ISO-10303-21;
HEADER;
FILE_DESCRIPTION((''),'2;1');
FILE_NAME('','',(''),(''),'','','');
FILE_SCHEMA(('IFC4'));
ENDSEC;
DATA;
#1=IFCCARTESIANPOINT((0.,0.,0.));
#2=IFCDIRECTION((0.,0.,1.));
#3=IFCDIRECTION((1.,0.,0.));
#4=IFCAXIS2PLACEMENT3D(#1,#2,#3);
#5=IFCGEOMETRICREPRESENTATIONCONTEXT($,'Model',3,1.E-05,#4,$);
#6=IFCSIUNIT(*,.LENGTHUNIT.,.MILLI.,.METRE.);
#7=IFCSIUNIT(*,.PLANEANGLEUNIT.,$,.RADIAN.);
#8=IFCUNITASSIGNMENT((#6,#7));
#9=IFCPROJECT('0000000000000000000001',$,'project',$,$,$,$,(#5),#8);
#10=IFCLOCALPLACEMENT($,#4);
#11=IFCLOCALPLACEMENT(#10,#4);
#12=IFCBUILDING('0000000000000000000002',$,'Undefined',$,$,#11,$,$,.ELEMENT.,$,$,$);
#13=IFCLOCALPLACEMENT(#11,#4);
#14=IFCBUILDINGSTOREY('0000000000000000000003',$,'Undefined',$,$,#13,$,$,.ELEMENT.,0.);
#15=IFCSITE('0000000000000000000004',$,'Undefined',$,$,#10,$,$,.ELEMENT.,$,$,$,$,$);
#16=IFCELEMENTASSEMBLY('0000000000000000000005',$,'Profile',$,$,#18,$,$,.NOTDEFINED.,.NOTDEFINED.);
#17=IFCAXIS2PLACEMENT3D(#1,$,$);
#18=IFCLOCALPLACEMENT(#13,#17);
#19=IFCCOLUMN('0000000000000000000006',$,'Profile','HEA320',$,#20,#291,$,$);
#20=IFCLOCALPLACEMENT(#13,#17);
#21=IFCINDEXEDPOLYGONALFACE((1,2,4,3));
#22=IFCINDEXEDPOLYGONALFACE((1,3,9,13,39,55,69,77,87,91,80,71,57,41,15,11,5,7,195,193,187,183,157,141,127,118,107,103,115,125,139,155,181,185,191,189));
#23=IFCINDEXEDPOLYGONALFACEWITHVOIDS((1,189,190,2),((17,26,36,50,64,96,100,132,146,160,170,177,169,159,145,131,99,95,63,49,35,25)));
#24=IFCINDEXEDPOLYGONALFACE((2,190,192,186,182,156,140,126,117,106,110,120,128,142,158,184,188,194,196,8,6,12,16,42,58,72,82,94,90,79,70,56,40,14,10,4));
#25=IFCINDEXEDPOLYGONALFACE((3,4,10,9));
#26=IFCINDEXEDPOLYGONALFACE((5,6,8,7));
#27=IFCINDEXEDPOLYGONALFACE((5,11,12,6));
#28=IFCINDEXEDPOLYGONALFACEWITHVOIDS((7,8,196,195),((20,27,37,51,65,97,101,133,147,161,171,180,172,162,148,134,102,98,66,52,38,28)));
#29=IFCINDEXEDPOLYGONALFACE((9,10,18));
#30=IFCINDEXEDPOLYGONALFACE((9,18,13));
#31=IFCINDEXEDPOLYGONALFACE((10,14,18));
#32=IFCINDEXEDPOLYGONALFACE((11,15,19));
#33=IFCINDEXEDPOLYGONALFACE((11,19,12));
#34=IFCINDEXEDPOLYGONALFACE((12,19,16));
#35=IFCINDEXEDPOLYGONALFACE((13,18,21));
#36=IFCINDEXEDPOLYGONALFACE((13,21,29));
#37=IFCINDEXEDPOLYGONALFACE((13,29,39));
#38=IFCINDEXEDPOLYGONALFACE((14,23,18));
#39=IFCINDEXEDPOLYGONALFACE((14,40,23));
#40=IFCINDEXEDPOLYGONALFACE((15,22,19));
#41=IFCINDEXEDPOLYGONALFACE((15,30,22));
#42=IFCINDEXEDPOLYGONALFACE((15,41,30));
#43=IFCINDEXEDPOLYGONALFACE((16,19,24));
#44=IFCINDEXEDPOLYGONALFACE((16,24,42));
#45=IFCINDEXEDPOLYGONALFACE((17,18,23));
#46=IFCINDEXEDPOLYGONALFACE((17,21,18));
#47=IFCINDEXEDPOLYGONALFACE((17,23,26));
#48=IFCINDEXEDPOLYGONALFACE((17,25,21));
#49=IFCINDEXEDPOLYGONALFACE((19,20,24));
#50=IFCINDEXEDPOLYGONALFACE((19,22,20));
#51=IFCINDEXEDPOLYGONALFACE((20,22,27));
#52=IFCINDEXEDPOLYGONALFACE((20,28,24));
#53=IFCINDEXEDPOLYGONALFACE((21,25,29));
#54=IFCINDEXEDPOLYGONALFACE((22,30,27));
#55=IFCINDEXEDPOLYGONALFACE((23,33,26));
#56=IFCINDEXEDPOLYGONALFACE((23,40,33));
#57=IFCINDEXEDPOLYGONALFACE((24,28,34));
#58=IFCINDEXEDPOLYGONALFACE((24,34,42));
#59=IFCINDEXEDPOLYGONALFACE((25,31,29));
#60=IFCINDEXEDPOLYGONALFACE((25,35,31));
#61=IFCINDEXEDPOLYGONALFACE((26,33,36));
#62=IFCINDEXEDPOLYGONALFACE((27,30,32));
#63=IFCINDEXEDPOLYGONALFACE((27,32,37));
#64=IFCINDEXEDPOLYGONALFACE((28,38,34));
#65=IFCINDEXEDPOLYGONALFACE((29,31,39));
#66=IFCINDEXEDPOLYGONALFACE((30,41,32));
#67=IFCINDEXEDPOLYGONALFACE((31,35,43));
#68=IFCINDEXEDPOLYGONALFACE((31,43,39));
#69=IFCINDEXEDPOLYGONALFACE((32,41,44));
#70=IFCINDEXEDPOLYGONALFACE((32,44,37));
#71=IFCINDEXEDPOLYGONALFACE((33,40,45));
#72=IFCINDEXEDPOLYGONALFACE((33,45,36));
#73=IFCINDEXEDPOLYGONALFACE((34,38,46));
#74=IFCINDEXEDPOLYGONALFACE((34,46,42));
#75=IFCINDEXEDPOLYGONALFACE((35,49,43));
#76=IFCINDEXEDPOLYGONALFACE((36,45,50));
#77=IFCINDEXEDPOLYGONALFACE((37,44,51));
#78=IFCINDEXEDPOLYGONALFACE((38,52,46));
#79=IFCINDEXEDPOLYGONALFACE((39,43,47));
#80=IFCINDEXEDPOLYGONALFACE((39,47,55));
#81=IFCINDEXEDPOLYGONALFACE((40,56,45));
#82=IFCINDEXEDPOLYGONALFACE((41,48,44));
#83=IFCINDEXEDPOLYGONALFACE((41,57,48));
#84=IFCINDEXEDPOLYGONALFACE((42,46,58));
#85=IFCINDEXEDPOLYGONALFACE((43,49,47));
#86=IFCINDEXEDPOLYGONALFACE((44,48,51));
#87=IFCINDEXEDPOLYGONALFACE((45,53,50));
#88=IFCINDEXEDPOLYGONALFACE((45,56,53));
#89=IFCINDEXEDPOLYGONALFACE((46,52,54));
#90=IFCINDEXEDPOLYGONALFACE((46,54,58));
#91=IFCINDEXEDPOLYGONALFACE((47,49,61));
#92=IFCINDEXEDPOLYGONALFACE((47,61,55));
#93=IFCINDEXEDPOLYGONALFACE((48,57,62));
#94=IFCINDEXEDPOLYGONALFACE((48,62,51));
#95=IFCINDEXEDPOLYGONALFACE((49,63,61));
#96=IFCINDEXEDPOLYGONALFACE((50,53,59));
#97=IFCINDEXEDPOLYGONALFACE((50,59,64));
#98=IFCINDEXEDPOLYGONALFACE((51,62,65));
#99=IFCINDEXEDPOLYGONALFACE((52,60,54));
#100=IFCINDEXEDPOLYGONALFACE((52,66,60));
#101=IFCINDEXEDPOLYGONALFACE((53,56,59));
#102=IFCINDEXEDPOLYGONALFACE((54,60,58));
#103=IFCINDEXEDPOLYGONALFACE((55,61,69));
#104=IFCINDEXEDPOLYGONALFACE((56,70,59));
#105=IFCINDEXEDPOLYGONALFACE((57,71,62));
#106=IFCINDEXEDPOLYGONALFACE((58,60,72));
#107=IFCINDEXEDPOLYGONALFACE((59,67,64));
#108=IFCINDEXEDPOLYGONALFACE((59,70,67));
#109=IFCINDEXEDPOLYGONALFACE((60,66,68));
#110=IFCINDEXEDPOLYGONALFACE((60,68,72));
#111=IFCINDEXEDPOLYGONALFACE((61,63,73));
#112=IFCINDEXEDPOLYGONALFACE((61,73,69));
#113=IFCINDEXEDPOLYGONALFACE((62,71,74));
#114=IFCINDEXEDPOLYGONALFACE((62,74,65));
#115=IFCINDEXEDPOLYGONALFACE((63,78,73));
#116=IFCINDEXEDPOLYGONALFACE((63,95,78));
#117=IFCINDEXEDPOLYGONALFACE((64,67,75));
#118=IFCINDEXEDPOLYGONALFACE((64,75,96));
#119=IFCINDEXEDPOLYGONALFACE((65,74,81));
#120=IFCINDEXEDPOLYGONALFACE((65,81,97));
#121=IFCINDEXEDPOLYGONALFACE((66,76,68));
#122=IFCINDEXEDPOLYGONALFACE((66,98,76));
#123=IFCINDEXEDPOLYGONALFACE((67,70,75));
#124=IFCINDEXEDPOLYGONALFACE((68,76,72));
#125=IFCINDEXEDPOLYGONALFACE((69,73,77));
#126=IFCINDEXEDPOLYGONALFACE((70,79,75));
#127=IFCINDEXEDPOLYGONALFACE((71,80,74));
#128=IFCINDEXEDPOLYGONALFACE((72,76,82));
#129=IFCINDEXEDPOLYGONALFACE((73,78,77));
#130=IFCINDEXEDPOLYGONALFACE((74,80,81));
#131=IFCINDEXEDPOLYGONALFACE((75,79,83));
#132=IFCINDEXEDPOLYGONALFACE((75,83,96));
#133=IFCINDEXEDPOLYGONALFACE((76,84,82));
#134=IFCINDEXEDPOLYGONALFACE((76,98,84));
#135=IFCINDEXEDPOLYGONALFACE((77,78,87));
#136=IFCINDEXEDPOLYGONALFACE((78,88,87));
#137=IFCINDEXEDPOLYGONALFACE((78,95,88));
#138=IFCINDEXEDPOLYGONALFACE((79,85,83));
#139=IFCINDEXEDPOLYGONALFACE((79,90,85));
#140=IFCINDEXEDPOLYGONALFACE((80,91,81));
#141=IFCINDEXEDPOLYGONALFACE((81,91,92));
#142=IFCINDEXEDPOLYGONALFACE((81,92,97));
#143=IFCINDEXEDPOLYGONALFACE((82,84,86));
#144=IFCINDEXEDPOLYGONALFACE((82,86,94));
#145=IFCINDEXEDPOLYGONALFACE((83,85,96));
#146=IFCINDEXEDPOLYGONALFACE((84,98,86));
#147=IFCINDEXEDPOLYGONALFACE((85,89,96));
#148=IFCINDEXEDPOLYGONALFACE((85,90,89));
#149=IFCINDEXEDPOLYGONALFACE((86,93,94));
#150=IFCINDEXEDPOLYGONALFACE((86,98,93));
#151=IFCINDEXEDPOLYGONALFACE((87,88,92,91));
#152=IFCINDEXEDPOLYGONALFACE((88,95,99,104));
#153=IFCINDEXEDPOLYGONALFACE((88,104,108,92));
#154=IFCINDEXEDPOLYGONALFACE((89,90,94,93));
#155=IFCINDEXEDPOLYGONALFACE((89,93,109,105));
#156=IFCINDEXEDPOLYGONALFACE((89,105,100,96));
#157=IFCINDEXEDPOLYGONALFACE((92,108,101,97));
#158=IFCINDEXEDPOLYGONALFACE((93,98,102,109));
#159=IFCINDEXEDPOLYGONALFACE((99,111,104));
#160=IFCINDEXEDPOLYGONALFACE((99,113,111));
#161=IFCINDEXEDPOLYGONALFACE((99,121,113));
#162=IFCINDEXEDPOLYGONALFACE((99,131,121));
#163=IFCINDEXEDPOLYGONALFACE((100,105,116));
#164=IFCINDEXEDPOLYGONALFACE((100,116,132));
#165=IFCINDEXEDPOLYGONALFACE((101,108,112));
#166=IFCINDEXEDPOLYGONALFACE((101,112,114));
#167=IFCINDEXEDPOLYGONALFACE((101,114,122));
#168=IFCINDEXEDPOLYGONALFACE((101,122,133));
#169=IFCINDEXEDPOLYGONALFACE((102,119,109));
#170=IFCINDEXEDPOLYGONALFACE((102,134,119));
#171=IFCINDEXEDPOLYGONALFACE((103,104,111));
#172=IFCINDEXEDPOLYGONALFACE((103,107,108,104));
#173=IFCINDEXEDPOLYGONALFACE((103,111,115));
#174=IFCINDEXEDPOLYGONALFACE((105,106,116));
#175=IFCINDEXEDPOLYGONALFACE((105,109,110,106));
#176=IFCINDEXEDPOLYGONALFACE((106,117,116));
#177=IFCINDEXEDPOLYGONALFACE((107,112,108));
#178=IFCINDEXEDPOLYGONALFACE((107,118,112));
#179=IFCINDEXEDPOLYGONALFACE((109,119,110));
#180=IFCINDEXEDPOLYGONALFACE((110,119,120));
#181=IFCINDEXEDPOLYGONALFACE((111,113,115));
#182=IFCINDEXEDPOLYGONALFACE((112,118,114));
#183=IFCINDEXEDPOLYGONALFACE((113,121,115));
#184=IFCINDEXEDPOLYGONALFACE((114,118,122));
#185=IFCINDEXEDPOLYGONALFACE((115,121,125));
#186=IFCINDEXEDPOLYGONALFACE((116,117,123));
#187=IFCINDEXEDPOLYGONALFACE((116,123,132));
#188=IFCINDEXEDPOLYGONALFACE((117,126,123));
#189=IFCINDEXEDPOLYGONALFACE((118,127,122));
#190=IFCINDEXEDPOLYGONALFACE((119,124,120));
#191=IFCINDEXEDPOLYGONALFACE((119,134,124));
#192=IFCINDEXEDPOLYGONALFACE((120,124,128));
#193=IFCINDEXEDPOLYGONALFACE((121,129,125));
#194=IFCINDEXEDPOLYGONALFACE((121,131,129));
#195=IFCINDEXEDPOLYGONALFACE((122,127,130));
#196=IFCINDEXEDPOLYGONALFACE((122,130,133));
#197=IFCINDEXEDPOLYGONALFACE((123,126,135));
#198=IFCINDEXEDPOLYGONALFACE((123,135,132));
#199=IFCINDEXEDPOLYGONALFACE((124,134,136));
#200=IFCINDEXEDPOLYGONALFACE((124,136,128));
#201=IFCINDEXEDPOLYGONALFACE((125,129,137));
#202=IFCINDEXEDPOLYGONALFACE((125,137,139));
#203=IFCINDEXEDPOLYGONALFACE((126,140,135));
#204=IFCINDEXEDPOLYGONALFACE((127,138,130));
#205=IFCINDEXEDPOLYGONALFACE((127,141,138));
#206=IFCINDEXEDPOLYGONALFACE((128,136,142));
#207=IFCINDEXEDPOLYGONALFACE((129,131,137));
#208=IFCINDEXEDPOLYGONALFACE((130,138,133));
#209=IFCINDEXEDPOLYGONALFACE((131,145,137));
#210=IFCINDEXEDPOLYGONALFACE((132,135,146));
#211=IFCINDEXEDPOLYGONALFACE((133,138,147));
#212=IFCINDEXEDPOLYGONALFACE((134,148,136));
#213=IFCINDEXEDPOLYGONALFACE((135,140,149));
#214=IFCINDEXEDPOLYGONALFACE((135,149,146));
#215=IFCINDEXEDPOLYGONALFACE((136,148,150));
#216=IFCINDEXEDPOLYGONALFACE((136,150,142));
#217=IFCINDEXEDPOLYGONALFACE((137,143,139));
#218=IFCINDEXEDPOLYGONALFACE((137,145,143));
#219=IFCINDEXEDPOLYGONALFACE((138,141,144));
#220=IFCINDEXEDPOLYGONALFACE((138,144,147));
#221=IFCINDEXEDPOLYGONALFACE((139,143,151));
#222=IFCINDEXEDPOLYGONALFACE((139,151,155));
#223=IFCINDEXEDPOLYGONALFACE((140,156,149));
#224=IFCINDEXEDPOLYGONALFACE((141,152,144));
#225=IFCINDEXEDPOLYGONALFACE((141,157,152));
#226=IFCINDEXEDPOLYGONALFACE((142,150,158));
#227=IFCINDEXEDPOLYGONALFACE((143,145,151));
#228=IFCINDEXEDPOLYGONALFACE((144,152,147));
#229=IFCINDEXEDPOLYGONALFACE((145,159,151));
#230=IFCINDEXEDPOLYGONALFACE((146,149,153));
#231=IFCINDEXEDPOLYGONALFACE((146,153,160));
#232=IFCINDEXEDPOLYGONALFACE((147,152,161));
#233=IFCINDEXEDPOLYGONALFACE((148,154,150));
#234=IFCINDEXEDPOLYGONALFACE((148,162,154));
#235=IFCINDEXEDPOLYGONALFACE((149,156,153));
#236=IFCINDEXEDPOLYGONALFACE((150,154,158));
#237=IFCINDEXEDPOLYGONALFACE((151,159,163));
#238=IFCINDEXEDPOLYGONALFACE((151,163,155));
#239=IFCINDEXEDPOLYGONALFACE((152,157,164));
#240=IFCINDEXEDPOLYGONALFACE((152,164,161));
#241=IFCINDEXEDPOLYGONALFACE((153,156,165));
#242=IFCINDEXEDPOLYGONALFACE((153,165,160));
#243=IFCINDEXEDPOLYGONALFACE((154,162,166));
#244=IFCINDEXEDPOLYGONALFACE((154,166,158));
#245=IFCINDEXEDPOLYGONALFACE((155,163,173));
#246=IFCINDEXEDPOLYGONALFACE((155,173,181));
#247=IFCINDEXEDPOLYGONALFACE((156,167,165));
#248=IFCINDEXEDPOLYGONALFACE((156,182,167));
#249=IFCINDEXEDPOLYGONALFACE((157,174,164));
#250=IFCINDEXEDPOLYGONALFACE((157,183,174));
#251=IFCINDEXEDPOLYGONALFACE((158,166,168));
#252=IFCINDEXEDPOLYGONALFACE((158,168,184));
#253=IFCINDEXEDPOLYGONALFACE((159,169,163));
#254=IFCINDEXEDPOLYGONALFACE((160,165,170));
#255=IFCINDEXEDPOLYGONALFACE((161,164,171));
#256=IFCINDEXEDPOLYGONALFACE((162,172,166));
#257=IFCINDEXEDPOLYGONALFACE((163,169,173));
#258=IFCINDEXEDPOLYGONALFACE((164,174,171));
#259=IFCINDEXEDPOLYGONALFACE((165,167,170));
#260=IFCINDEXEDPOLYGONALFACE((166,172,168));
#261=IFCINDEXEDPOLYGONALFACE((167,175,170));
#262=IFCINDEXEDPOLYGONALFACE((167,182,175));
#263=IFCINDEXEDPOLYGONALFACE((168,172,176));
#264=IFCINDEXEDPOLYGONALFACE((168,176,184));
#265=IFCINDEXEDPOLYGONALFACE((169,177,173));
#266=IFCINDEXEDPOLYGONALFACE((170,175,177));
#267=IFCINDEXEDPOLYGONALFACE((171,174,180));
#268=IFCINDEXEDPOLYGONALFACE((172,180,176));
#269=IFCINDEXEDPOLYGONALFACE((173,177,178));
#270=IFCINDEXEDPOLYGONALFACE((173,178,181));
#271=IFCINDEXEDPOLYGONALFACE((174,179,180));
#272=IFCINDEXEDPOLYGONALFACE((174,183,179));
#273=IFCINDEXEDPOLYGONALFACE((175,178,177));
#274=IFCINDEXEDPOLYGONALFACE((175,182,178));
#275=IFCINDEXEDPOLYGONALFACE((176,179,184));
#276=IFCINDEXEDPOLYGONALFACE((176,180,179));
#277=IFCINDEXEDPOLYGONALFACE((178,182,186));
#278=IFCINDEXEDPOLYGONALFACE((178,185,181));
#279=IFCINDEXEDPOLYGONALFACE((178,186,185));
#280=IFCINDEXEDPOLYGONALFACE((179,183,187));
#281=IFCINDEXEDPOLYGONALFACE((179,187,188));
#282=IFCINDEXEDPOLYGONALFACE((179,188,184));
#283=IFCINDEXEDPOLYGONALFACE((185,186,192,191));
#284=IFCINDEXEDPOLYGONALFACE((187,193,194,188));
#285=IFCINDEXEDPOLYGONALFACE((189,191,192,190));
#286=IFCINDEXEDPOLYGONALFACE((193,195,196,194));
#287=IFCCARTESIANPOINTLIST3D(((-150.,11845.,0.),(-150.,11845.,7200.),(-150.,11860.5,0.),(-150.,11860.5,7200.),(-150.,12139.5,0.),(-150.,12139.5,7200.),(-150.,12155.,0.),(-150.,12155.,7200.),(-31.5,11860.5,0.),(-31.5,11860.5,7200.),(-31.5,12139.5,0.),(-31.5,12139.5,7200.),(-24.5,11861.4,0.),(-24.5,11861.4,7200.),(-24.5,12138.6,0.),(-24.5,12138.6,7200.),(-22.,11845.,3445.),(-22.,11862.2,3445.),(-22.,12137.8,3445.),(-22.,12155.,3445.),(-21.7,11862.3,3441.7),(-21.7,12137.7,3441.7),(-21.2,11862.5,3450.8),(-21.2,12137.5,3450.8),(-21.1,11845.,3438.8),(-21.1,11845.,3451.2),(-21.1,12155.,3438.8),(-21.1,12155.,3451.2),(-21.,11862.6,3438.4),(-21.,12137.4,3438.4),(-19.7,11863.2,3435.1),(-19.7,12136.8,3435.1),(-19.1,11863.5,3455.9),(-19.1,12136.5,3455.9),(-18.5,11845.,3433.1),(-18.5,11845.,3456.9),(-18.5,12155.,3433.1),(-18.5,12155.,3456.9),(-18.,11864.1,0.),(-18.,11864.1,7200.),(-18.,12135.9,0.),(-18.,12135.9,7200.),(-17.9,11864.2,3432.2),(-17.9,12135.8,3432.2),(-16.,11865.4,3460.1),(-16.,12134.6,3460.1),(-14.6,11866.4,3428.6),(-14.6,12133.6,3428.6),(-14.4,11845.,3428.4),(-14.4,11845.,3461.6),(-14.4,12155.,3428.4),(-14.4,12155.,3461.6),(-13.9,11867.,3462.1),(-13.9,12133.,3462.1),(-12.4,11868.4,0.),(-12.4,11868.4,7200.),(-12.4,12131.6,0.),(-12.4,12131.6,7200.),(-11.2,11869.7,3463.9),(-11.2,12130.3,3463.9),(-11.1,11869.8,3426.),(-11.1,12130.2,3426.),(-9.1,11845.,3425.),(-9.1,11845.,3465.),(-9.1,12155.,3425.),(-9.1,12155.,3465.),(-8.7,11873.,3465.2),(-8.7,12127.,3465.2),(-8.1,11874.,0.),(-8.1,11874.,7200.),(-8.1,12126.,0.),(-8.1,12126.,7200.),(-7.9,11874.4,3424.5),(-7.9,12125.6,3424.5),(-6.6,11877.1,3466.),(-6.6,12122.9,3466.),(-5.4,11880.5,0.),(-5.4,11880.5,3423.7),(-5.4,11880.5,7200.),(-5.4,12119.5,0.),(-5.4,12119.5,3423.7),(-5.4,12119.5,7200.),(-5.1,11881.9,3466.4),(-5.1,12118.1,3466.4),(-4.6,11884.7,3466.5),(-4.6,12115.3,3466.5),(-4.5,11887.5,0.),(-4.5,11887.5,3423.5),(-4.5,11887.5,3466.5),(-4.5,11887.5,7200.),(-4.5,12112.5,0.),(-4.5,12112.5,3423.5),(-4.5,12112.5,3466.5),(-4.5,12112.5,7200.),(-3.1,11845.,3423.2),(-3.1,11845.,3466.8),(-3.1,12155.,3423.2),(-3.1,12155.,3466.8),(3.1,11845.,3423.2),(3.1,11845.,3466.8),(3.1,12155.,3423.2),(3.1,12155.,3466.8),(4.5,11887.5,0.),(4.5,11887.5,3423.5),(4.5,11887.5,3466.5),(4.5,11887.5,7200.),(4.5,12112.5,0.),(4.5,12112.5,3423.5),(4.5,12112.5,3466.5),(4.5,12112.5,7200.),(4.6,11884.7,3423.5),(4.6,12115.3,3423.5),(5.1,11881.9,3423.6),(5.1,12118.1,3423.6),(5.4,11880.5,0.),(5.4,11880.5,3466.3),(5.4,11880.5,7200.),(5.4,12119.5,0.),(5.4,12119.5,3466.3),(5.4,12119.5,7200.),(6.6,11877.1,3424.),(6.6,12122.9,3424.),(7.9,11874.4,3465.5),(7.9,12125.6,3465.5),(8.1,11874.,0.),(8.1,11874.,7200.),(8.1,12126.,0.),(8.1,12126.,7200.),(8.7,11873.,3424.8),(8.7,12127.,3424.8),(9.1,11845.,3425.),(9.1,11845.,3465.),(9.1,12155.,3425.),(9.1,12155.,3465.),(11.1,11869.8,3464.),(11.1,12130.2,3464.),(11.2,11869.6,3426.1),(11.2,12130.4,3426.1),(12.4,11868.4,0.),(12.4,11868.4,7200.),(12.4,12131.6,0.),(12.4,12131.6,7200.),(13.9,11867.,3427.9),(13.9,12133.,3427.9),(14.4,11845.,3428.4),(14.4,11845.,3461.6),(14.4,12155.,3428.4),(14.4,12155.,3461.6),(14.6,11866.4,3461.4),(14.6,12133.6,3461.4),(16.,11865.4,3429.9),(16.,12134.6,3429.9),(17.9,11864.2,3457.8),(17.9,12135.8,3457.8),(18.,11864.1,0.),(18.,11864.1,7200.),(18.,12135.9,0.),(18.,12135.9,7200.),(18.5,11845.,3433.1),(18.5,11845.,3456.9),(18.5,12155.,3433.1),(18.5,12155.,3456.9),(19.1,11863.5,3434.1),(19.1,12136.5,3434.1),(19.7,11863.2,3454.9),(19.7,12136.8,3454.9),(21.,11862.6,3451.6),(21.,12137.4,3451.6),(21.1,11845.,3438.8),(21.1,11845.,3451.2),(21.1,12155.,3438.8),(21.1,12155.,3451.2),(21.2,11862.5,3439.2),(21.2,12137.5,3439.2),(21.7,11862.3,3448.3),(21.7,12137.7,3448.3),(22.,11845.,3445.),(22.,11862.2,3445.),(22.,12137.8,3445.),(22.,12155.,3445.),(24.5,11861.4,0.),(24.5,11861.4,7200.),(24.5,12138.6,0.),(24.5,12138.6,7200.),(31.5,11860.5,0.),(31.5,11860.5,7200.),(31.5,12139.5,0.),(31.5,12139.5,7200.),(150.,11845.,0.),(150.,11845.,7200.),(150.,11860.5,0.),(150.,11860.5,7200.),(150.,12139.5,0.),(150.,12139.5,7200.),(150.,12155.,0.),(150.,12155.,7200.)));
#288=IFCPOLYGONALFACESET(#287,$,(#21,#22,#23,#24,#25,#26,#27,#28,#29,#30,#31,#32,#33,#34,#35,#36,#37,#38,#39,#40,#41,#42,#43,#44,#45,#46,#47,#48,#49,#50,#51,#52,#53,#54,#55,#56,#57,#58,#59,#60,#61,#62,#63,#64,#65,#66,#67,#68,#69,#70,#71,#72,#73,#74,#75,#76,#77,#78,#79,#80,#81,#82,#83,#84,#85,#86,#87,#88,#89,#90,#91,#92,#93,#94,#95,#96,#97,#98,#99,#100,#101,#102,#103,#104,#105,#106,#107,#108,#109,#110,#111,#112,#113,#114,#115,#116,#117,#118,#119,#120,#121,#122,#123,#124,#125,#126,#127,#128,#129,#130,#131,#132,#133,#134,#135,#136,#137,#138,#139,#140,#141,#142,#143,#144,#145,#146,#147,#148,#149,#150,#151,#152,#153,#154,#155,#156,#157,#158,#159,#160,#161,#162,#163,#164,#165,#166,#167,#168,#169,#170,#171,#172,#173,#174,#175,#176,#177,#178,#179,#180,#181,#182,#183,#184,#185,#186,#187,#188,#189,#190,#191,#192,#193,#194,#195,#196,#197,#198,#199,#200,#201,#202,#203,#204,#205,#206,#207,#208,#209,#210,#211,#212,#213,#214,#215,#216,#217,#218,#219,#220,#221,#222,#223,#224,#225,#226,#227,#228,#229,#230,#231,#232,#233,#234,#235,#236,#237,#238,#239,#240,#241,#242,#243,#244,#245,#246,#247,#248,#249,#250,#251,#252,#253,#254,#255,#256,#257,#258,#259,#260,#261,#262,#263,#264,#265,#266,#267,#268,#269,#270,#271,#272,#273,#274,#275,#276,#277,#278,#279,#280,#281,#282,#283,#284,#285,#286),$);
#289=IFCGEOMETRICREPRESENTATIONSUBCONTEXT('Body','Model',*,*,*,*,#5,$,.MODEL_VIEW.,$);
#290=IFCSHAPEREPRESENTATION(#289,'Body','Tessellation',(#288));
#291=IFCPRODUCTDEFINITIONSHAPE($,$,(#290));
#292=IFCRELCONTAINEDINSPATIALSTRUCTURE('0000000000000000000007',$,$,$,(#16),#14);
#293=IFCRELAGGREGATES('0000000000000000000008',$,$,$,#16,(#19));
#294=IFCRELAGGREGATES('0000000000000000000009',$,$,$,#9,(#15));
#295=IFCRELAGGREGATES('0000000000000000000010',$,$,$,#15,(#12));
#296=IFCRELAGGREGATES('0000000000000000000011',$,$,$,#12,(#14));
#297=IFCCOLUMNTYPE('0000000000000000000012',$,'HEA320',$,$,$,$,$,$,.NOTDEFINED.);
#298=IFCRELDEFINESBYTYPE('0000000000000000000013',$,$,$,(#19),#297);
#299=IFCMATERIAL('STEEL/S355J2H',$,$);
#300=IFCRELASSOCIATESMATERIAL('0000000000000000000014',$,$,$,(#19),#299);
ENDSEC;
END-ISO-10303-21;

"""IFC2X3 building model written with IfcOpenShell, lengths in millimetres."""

from ifc_helpers import new_model, si_unit, frame, origin_with_axes, origin_2d_with_axis, place, context, subcontext, project, spatial, circle, i_section, extrude, material, type_object, element, aggregate, save


model = new_model("IFC2X3")

# Units and contexts
model_context = context("Model", 3, precision=1e-05, world=origin_with_axes())
body_context = subcontext(model_context, "Body", "Model", "MODEL_VIEW")
ifc_project = project(units=[si_unit("LENGTHUNIT", "METRE", prefix="MILLI"), si_unit("PLANEANGLEUNIT", "RADIAN")], contexts=[model_context])

# Site, building, storey
site_placement = place(None, origin_with_axes())
site = spatial("IfcSite", under=ifc_project, at=site_placement, Name="Undefined", CompositionType="ELEMENT")
building_placement = place(site_placement, origin_with_axes())
building = spatial("IfcBuilding", under=site, at=building_placement, Name="Undefined", CompositionType="ELEMENT")
storey_placement = place(building_placement, origin_with_axes())
storey = spatial("IfcBuildingStorey", under=building, at=storey_placement, Name="Undefined", CompositionType="ELEMENT", Elevation=0.0)

# Element assembly, column, openings
assembly_1_placement = place(storey_placement, origin_with_axes())
assembly_1 = element("IfcElementAssembly", 1, at=assembly_1_placement, inside=storey, Name="Profile", AssemblyPlace="NOTDEFINED", PredefinedType="NOTDEFINED")
ifc_material_1 = material(Name="STEEL/S355J2H")
column_type = type_object("IfcColumnType", Name="HEA320", PredefinedType="NOTDEFINED")
column_placement = place(assembly_1_placement, frame((0.0, 12000.0, 0.0), z_axis=(0.0, 0.0, 1.0), x_axis=(0.0, 1.0, 0.0)))
column = element("IfcColumn", 2, at=column_placement, type_object=column_type, material=ifc_material_1, Name="Profile", Description="HEA320", context=body_context, shape_type="SweptSolid", body=[
    extrude(i_section(OverallWidth=300.0, OverallDepth=310.0, WebThickness=9.0, FlangeThickness=15.5, FilletRadius=27.0, at=origin_2d_with_axis()), frame((0.0, 0.0, 7200.0), z_axis=(0.0, 0.0, -1.0), x_axis=(0.0, 1.0, 0.0)), (0.0, 0.0, 1.0), 7200.0),
])
opening_1_placement = place(assembly_1_placement, frame((0.0, 12000.0, 0.0), z_axis=(0.0, 0.0, 1.0), x_axis=(0.0, 1.0, 0.0)))
element("IfcOpeningElement", 3, at=opening_1_placement, cuts=column, ObjectType="Recess", context=body_context, shape_type="SweptSolid", body=[
    extrude(circle(Radius=22.0, at=origin_2d_with_axis()), frame((156.0, 0.0, 3445.0), z_axis=(-1.0, 0.0, 0.0), x_axis=(0.0, -1.0, 0.0)), (0.0, 0.0, 1.0), 312.0),
])
opening_2_placement = place(assembly_1_placement, frame((0.0, 12000.0, 0.0), z_axis=(0.0, 0.0, 1.0), x_axis=(0.0, 1.0, 0.0)))
element("IfcOpeningElement", 4, at=opening_2_placement, cuts=column, ObjectType="Recess", context=body_context, shape_type="SweptSolid", body=[
    extrude(circle(Radius=22.0, at=origin_2d_with_axis()), frame((-156.0, 0.0, 3445.0), z_axis=(1.0, 0.0, 0.0), x_axis=(0.0, 1.0, 0.0)), (0.0, 0.0, 1.0), 312.0),
])

aggregate(assembly_1, [column])

save(model, "model.ifc")
